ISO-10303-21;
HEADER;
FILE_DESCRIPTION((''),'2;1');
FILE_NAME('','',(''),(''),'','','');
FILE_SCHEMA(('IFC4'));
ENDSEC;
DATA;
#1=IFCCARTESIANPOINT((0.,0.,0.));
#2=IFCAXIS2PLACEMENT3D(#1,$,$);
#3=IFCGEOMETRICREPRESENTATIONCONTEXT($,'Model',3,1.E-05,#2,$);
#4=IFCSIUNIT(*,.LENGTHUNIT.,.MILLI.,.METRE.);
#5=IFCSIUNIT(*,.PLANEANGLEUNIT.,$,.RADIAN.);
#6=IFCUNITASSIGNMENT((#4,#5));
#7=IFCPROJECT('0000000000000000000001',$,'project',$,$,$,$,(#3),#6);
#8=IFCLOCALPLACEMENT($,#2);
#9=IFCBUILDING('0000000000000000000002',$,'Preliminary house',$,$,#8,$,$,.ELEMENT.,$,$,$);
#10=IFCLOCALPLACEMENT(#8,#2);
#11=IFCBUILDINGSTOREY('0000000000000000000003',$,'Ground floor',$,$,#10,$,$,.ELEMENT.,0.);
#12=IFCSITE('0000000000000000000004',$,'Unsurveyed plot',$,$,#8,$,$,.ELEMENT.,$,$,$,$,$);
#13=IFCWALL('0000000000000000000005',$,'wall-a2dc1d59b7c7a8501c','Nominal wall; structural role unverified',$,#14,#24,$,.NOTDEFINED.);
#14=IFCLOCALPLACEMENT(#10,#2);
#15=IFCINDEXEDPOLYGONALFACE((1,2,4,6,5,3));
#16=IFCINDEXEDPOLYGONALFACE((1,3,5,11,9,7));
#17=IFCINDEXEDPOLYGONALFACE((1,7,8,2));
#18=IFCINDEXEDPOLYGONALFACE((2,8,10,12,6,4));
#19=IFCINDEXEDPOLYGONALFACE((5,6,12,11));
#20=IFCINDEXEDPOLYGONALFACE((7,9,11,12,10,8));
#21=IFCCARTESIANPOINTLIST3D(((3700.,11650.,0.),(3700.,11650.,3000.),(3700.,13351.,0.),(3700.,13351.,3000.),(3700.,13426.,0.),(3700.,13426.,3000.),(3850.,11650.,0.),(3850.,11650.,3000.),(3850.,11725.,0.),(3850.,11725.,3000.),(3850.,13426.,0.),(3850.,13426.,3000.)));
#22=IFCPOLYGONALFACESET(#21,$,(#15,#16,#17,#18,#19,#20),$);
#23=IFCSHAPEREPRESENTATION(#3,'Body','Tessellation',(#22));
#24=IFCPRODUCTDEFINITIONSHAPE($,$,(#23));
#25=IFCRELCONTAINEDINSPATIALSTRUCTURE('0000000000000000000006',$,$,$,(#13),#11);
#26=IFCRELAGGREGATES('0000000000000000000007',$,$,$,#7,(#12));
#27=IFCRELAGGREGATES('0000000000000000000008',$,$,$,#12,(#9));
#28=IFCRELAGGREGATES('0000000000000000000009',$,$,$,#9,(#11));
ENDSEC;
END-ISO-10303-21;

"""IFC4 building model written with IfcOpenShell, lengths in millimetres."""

from ifc_helpers import new_model, si_unit, origin, place, context, project, spatial, polyline, outline, extrude, element, save


model = new_model("IFC4")

# Units and contexts
model_context = context("Model", 3, precision=1e-05, world=origin())
ifc_project = project(units=[si_unit("LENGTHUNIT", "METRE", prefix="MILLI"), si_unit("PLANEANGLEUNIT", "RADIAN")], contexts=[model_context])

# Site, building, storey
placement_1 = place(None, origin())
site = spatial("IfcSite", under=ifc_project, at=placement_1, Name="Unsurveyed plot", CompositionType="ELEMENT")
building = spatial("IfcBuilding", under=site, at=placement_1, Name="Preliminary house", CompositionType="ELEMENT")
placement_2 = place(placement_1, origin())
storey = spatial("IfcBuildingStorey", under=building, at=placement_2, Name="Ground floor", CompositionType="ELEMENT", Elevation=0.0)

# Wall
element("IfcWall", 1, at=placement_2, inside=storey, Name="wall-a2dc1d59b7c7a8501c", Description="Nominal wall; structural role unverified", PredefinedType="NOTDEFINED", context=model_context, shape_type="SweptSolid", body=[
    extrude(outline(polyline([(3700.0, 13351.0), (3700.0, 13426.0), (3850.0, 13426.0), (3850.0, 11725.0), (3850.0, 11650.0), (3700.0, 11650.0), (3700.0, 13351.0)])), origin(), (0.0, 0.0, 1.0), 3000.0),
])

save(model, "model.ifc")
